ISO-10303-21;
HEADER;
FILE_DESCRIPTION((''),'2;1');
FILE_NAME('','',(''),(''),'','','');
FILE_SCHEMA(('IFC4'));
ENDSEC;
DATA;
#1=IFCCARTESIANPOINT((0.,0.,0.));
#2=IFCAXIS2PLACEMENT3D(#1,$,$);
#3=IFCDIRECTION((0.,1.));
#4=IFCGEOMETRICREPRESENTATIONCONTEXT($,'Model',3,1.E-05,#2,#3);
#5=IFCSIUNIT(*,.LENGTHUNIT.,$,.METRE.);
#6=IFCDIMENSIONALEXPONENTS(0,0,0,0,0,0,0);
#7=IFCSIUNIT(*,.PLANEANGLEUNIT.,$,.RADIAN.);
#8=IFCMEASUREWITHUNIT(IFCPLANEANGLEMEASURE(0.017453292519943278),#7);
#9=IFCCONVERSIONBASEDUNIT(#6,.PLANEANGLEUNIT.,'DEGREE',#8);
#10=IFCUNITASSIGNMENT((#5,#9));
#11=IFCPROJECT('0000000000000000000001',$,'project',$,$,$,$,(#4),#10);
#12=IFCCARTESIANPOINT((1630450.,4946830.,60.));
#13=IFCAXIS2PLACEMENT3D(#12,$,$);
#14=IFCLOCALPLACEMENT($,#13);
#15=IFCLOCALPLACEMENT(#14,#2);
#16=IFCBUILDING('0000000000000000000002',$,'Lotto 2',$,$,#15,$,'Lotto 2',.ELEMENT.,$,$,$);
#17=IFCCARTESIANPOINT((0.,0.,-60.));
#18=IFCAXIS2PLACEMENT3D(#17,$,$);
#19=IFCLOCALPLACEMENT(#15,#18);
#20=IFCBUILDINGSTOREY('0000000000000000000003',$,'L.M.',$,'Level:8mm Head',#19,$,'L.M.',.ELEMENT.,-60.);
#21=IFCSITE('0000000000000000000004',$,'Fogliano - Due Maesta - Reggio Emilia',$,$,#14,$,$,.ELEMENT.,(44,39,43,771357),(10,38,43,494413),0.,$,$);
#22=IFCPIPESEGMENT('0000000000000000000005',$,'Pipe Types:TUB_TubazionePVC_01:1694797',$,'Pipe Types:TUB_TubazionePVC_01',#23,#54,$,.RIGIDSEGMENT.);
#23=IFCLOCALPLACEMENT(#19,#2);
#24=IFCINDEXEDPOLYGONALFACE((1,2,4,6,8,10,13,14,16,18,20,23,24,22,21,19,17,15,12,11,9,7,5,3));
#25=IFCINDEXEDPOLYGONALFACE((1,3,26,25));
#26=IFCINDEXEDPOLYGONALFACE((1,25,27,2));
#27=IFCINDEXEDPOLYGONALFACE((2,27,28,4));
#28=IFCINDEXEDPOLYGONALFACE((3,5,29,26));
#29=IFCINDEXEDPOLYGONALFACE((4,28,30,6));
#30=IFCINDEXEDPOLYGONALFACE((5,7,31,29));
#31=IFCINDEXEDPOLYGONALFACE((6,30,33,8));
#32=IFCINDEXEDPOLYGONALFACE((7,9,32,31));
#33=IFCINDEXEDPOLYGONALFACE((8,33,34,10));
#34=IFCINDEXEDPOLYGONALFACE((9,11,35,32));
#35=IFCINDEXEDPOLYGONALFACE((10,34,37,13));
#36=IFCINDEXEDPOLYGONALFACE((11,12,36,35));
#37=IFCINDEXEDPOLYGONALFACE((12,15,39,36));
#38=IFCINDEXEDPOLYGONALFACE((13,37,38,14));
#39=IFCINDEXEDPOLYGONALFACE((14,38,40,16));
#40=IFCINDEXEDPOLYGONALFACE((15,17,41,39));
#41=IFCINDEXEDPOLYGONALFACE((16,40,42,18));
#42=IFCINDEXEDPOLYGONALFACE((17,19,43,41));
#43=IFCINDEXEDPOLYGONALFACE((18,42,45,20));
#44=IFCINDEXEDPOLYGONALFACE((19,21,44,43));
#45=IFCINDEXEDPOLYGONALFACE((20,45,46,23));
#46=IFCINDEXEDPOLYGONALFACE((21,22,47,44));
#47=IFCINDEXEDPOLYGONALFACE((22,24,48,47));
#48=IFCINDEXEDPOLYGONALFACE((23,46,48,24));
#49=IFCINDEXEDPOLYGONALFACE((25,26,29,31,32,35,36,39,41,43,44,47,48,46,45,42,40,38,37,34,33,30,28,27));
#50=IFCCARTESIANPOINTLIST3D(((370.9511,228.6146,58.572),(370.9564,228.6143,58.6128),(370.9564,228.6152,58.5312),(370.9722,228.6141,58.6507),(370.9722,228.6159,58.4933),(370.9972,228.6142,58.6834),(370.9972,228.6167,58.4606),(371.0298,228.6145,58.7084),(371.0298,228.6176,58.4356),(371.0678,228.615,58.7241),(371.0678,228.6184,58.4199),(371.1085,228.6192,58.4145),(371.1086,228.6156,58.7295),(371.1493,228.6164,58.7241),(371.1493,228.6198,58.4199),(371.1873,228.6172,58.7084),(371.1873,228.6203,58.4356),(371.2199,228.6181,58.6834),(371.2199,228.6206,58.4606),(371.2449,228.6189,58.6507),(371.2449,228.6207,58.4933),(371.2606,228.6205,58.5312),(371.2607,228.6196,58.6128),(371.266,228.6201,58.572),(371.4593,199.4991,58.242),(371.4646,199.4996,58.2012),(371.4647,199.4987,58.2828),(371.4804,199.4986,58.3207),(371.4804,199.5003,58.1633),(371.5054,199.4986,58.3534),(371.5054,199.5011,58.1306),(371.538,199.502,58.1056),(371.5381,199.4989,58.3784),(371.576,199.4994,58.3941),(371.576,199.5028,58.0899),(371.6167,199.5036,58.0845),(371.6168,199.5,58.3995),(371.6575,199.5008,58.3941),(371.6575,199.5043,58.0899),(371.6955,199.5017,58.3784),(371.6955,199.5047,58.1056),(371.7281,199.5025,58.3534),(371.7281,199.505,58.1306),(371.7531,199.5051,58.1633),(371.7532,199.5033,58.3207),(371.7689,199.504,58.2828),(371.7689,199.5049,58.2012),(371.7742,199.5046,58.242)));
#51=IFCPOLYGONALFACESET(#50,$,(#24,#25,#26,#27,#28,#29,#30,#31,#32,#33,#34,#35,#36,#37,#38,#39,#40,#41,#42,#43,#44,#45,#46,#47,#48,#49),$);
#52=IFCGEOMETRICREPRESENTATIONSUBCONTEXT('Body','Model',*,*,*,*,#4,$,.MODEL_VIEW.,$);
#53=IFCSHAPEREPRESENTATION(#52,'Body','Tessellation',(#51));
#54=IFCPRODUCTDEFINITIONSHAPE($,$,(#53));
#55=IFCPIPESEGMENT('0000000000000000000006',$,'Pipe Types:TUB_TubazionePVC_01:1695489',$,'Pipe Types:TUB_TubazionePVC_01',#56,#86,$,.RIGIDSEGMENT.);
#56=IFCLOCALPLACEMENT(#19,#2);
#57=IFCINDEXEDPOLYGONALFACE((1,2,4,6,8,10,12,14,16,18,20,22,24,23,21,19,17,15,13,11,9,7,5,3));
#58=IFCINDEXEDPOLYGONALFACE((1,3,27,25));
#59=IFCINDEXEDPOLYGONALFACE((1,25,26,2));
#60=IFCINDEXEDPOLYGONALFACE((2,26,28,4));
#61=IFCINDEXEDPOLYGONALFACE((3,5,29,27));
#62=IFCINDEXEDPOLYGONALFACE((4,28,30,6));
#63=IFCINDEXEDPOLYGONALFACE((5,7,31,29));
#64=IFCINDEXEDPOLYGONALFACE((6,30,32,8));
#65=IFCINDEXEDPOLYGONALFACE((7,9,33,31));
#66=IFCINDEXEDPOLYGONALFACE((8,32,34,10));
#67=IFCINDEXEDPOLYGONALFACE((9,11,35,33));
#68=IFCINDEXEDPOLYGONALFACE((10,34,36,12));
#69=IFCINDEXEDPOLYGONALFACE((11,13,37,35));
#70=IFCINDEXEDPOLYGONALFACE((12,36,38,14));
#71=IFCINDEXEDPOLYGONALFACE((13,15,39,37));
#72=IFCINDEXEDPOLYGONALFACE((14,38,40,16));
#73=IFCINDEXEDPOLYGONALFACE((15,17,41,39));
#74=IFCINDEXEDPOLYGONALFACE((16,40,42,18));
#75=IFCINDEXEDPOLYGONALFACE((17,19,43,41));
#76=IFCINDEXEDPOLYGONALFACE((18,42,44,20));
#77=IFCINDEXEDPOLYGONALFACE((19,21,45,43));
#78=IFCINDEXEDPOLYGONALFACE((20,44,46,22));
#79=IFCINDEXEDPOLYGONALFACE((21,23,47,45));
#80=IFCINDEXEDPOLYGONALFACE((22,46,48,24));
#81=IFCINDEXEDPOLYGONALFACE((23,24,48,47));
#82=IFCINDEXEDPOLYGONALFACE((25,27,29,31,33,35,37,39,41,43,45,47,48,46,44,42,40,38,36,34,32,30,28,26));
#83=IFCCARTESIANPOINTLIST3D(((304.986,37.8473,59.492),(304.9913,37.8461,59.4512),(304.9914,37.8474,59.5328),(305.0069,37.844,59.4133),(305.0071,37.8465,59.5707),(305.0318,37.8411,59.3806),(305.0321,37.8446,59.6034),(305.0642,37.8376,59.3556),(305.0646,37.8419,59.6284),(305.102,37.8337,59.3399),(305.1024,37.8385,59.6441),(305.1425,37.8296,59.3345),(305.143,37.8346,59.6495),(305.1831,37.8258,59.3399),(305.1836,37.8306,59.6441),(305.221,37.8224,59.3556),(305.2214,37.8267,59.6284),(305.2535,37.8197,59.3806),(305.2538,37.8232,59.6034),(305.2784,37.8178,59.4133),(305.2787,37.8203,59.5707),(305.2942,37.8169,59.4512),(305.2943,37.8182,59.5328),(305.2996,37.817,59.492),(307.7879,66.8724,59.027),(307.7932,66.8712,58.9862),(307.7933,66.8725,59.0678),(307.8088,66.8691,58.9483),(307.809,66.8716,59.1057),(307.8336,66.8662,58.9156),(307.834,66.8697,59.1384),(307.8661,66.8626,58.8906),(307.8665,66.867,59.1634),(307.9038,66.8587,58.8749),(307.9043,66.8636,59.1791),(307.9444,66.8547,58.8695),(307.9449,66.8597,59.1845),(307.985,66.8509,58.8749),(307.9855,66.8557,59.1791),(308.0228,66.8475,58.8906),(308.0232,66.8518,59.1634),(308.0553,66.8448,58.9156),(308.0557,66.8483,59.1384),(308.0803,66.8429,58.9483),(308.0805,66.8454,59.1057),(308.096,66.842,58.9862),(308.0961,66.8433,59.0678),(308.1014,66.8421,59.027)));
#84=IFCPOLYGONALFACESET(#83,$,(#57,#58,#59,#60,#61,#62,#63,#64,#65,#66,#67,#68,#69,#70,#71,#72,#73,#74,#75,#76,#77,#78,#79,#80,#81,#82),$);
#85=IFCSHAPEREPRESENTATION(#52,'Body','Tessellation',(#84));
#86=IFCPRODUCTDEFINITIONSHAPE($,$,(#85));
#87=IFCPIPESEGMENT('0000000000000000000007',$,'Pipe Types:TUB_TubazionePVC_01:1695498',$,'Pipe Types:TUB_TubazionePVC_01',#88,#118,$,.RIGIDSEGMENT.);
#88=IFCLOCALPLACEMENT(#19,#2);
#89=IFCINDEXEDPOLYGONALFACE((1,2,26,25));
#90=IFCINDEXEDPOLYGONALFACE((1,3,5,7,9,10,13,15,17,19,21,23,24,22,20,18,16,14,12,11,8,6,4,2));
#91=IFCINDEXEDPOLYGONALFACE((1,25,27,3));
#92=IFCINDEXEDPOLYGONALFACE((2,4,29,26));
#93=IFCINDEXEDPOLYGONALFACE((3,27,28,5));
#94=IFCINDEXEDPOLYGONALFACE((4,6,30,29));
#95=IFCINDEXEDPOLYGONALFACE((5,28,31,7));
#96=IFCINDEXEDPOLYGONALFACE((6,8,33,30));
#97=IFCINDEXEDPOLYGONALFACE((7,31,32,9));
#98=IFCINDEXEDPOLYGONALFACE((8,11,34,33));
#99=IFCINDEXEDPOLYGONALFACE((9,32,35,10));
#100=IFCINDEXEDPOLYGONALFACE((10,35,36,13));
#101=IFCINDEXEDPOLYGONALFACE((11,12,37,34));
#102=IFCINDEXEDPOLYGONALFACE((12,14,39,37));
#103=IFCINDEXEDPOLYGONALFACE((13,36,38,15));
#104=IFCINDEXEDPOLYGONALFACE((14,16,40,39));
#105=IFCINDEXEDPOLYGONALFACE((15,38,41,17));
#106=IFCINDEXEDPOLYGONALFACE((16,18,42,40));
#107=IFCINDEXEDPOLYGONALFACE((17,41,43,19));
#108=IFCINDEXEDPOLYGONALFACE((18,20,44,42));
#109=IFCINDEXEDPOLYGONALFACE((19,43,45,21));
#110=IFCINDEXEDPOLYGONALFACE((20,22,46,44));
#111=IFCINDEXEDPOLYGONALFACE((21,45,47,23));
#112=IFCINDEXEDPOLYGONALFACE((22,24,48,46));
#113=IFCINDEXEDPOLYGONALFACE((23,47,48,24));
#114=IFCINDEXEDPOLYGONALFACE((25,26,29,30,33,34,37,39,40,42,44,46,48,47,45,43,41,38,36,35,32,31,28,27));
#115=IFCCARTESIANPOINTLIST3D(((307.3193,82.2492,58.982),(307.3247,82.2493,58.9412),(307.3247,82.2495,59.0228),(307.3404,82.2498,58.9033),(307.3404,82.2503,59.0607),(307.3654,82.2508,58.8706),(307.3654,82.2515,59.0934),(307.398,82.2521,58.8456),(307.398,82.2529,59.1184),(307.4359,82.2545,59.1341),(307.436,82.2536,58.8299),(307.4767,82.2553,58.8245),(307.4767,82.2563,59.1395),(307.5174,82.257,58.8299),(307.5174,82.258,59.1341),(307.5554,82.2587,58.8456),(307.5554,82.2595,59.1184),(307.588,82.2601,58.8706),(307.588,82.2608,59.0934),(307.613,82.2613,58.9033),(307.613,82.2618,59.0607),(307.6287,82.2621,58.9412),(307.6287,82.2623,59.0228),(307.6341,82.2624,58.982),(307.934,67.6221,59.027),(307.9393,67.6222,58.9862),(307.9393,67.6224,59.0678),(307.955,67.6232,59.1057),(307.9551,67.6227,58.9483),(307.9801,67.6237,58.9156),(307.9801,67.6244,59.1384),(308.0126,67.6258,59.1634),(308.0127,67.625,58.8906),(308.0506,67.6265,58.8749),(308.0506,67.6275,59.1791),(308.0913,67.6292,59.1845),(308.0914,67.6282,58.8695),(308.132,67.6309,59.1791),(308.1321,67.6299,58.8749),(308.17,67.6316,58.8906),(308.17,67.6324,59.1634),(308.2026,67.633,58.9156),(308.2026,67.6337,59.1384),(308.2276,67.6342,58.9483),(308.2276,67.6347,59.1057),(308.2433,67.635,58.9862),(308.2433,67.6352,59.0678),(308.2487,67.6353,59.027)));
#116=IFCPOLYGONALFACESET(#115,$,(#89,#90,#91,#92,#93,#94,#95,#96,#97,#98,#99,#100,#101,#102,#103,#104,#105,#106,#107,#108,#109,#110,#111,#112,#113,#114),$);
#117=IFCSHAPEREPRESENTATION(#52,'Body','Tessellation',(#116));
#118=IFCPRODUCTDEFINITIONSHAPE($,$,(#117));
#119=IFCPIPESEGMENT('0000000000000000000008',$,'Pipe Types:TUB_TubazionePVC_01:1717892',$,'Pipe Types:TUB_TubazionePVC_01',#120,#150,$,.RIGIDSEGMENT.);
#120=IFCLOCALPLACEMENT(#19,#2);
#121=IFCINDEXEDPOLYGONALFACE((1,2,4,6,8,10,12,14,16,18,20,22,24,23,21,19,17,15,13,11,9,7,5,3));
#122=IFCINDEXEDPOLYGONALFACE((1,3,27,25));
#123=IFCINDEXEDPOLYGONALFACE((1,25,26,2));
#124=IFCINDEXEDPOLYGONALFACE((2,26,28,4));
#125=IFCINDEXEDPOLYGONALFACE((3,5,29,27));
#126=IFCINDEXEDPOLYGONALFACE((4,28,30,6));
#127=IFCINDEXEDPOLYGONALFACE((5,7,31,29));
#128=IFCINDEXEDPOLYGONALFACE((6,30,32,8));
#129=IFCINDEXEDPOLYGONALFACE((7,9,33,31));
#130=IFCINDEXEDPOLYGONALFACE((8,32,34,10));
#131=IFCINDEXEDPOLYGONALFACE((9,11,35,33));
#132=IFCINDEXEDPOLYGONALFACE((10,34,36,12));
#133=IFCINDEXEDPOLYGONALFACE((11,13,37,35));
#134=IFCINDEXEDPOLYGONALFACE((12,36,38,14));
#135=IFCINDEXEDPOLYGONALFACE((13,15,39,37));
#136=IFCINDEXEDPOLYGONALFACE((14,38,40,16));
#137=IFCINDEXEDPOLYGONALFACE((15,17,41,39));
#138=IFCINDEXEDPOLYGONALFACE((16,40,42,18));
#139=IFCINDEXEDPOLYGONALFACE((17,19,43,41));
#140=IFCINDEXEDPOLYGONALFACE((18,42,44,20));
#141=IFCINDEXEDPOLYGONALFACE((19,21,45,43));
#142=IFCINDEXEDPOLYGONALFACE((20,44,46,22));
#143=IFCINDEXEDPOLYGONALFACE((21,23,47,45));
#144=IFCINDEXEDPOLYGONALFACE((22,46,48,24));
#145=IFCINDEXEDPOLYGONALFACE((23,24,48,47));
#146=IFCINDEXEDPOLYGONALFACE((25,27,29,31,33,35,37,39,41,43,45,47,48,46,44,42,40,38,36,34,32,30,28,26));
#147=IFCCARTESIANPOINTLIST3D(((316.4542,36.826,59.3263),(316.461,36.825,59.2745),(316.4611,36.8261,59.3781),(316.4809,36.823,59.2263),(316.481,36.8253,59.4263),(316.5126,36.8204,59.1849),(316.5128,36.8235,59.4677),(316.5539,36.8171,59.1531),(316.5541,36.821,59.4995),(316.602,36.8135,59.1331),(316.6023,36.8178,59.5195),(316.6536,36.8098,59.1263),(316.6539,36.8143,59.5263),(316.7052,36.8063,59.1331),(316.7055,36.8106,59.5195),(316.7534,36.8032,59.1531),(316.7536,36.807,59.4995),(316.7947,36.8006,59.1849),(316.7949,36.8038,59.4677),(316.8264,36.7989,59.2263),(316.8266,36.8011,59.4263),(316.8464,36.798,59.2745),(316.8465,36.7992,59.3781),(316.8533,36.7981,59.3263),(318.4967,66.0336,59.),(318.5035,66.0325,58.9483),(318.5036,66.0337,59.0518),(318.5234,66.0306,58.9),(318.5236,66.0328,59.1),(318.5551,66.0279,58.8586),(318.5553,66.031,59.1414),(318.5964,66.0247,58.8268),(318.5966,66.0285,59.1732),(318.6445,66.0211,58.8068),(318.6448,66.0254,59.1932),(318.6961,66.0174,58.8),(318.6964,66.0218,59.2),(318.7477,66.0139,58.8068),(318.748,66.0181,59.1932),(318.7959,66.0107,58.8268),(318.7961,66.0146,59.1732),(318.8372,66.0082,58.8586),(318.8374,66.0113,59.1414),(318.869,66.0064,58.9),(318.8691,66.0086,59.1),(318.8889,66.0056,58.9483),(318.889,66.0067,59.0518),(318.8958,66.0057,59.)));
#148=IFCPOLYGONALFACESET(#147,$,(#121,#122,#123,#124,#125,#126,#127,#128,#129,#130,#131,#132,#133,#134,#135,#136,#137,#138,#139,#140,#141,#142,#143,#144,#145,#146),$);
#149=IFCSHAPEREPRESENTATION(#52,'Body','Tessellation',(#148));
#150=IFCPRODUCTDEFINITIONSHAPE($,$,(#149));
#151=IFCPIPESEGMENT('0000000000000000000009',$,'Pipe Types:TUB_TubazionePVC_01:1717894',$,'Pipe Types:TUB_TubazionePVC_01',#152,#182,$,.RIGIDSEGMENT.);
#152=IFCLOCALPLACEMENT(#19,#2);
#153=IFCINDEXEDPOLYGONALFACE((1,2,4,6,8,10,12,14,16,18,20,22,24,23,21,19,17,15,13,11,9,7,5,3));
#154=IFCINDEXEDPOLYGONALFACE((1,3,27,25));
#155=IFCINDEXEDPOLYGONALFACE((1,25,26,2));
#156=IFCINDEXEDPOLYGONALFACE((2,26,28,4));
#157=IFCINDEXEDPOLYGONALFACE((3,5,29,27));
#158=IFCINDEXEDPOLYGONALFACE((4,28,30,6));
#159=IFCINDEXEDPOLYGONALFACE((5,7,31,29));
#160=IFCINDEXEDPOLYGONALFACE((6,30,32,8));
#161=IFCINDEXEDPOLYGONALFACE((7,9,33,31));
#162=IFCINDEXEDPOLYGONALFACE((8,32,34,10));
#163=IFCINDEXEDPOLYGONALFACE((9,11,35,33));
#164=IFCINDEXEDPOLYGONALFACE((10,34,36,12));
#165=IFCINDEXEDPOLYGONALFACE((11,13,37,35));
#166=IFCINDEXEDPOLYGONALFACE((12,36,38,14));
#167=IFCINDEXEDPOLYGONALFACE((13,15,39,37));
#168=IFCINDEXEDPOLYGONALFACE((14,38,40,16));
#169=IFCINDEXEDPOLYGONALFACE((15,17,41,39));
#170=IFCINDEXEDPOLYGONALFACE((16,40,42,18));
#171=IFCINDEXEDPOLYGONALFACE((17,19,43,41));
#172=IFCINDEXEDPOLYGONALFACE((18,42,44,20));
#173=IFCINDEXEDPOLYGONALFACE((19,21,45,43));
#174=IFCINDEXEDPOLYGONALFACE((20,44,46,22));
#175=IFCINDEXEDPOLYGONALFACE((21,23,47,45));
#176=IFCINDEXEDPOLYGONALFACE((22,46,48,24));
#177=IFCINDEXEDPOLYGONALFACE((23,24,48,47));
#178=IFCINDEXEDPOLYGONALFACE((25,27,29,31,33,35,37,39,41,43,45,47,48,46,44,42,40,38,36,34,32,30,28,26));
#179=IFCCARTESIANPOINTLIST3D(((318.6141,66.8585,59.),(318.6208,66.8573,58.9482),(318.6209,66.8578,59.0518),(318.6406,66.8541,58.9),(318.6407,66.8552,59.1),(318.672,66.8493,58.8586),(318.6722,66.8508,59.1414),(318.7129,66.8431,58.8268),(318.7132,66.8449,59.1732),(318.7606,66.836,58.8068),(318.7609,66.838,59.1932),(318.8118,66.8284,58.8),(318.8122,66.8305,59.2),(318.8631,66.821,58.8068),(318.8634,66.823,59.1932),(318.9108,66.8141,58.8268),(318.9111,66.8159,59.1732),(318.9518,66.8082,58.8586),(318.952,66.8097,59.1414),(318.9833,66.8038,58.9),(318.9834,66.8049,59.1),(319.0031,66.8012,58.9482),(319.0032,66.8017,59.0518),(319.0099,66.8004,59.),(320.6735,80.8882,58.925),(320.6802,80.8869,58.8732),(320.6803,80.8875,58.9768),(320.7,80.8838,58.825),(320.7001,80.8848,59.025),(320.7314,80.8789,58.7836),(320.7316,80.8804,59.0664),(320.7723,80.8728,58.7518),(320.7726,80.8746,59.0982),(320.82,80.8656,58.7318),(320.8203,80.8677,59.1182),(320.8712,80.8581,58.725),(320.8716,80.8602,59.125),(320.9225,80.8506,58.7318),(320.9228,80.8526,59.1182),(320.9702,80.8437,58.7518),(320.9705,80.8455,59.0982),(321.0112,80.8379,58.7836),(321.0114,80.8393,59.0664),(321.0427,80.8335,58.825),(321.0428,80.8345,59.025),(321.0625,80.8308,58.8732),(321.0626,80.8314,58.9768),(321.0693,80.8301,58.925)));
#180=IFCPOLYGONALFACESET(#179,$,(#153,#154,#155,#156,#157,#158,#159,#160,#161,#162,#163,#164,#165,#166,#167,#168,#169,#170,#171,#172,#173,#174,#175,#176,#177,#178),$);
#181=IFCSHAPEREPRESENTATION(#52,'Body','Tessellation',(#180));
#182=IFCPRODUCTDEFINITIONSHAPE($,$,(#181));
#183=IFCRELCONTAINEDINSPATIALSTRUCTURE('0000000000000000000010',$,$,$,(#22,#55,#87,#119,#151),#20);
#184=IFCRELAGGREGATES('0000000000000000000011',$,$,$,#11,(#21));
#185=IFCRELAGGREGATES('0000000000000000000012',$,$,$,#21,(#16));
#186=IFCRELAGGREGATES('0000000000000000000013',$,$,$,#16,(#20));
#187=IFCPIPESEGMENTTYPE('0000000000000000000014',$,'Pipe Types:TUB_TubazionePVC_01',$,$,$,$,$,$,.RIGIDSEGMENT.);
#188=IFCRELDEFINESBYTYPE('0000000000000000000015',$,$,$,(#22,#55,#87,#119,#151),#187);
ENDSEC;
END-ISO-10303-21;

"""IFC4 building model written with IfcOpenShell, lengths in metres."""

from ifc_helpers import new_model, entity, si_unit, converted_unit, direction, frame, origin, place, context, subcontext, project, spatial, arc, indexed_curve, outline, extrude, type_object, element, save


model = new_model("IFC4")

# Units and contexts
model_context = context("Model", 3, precision=1e-05, world=origin(), true_north=direction((0.0, 1.0)))
body_context = subcontext(model_context, "Body", "Model", "MODEL_VIEW")
ifc_project = project(units=[si_unit("LENGTHUNIT", "METRE"), converted_unit("PLANEANGLEUNIT", "DEGREE", entity("IfcPlaneAngleMeasure", 0.017453292519943278), si_unit("PLANEANGLEUNIT", "RADIAN"), dimensions=[0, 0, 0, 0, 0, 0, 0])], contexts=[model_context])

# Site, building, storey
site_placement = place(None, frame((1630450.0, 4946830.0, 60.0)))
site = spatial("IfcSite", under=ifc_project, at=site_placement, Name="Fogliano - Due Maesta - Reggio Emilia", CompositionType="ELEMENT", RefLatitude=(44, 39, 43, 771357), RefLongitude=(10, 38, 43, 494413), RefElevation=0.0)
building_placement = place(site_placement, origin())
building = spatial("IfcBuilding", under=site, at=building_placement, Name="Lotto 2", LongName="Lotto 2", CompositionType="ELEMENT")
storey_placement = place(building_placement, frame((0.0, 0.0, -60.0)))
storey = spatial("IfcBuildingStorey", under=building, at=storey_placement, Name="L.M.", ObjectType="Level:8mm Head", LongName="L.M.", CompositionType="ELEMENT", Elevation=-60.0)

# Pipe segments
pipe_segment_type = type_object("IfcPipeSegmentType", Name="Pipe Types:TUB_TubazionePVC_01", PredefinedType="RIGIDSEGMENT")
pipe_segment_1_placement = place(storey_placement, origin())
element("IfcPipeSegment", 1, at=pipe_segment_1_placement, inside=storey, type_object=pipe_segment_type, Name="Pipe Types:TUB_TubazionePVC_01:1694797", ObjectType="Pipe Types:TUB_TubazionePVC_01", PredefinedType="RIGIDSEGMENT", context=body_context, shape_type="SweptSolid", body=[
    extrude(outline(indexed_curve([(0.1575, 0.0), (0.1114, 0.1114), (0.0, 0.1575), (-0.1114, 0.1114), (-0.1575, 0.0), (-0.1114, -0.1114), (0.0, -0.1575), (0.1114, -0.1114)], segments=[arc(1, 2, 3), arc(3, 4, 5), arc(5, 6, 7), arc(7, 8, 1)], self_intersect=False)), frame((371.1085, 228.6174, 58.572), z_axis=(0.017451, -0.999783, -0.011332), x_axis=(0.999848, 0.017452, 0.0)), (0.0, 0.0, 1.0), 29.1219),
])
pipe_segment_2_placement = place(storey_placement, origin())
element("IfcPipeSegment", 2, at=pipe_segment_2_placement, inside=storey, type_object=pipe_segment_type, Name="Pipe Types:TUB_TubazionePVC_01:1695489", ObjectType="Pipe Types:TUB_TubazionePVC_01", PredefinedType="RIGIDSEGMENT", context=body_context, shape_type="SweptSolid", body=[
    extrude(outline(indexed_curve([(0.1575, 0.0), (0.1114, 0.1114), (0.0, 0.1575), (-0.1114, 0.1114), (-0.1575, 0.0), (-0.1114, -0.1114), (0.0, -0.1575), (0.1114, -0.1114)], segments=[arc(1, 2, 3), arc(3, 4, 5), arc(5, 6, 7), arc(7, 8, 1)], self_intersect=False)), frame((307.9446, 66.8572, 59.027), z_axis=(-0.096074, -0.995247, 0.015944), x_axis=(0.995373, -0.096086, 0.0)), (0.0, 0.0, 1.0), 29.1637),
])
pipe_segment_3_placement = place(storey_placement, origin())
element("IfcPipeSegment", 3, at=pipe_segment_3_placement, inside=storey, type_object=pipe_segment_type, Name="Pipe Types:TUB_TubazionePVC_01:1695498", ObjectType="Pipe Types:TUB_TubazionePVC_01", PredefinedType="RIGIDSEGMENT", context=body_context, shape_type="SweptSolid", body=[
    extrude(outline(indexed_curve([(0.1575, 0.0), (0.1114, 0.1114), (0.0, 0.1575), (-0.1114, 0.1114), (-0.1575, 0.0), (-0.1114, -0.1114), (0.0, -0.1575), (0.1114, -0.1114)], segments=[arc(1, 2, 3), arc(3, 4, 5), arc(5, 6, 7), arc(7, 8, 1)], self_intersect=False)), frame((307.4767, 82.2558, 58.982), z_axis=(0.041984, -0.999114, 0.003074), x_axis=(0.999118, 0.041984, 0.0)), (0.0, 0.0, 1.0), 14.6401),
])
pipe_segment_4_placement = place(storey_placement, origin())
element("IfcPipeSegment", 4, at=pipe_segment_4_placement, inside=storey, type_object=pipe_segment_type, Name="Pipe Types:TUB_TubazionePVC_01:1717892", ObjectType="Pipe Types:TUB_TubazionePVC_01", PredefinedType="RIGIDSEGMENT", context=body_context, shape_type="SweptSolid", body=[
    extrude(outline(indexed_curve([(0.2, 0.0), (0.1414, 0.1414), (0.0, 0.2), (-0.1414, 0.1414), (-0.2, 0.0), (-0.1414, -0.1414), (0.0, -0.2), (0.1414, -0.1414)], segments=[arc(1, 2, 3), arc(3, 4, 5), arc(5, 6, 7), arc(7, 8, 1)], self_intersect=False)), frame((318.6963, 66.0196, 59.0), z_axis=(-0.069756, -0.997502, 0.011143), x_axis=(-0.997564, 0.069761, 0.0)), (0.0, 0.0, 1.0), 29.2807),
])
pipe_segment_5_placement = place(storey_placement, origin())
element("IfcPipeSegment", 5, at=pipe_segment_5_placement, inside=storey, type_object=pipe_segment_type, Name="Pipe Types:TUB_TubazionePVC_01:1717894", ObjectType="Pipe Types:TUB_TubazionePVC_01", PredefinedType="RIGIDSEGMENT", context=body_context, shape_type="SweptSolid", body=[
    extrude(outline(indexed_curve([(0.2, 0.0), (0.1414, 0.1414), (0.0, 0.2), (-0.1414, 0.1414), (-0.2, 0.0), (-0.1414, -0.1414), (0.0, -0.2), (0.1414, -0.1414)], segments=[arc(1, 2, 3), arc(3, 4, 5), arc(5, 6, 7), arc(7, 8, 1)], self_intersect=False)), frame((318.812, 66.8295, 59.0), z_axis=(0.145231, 0.989384, -0.005289), x_axis=(-0.989398, 0.145233, 0.0)), (0.0, 0.0, 1.0), 14.1802),
])

save(model, "model.ifc")
